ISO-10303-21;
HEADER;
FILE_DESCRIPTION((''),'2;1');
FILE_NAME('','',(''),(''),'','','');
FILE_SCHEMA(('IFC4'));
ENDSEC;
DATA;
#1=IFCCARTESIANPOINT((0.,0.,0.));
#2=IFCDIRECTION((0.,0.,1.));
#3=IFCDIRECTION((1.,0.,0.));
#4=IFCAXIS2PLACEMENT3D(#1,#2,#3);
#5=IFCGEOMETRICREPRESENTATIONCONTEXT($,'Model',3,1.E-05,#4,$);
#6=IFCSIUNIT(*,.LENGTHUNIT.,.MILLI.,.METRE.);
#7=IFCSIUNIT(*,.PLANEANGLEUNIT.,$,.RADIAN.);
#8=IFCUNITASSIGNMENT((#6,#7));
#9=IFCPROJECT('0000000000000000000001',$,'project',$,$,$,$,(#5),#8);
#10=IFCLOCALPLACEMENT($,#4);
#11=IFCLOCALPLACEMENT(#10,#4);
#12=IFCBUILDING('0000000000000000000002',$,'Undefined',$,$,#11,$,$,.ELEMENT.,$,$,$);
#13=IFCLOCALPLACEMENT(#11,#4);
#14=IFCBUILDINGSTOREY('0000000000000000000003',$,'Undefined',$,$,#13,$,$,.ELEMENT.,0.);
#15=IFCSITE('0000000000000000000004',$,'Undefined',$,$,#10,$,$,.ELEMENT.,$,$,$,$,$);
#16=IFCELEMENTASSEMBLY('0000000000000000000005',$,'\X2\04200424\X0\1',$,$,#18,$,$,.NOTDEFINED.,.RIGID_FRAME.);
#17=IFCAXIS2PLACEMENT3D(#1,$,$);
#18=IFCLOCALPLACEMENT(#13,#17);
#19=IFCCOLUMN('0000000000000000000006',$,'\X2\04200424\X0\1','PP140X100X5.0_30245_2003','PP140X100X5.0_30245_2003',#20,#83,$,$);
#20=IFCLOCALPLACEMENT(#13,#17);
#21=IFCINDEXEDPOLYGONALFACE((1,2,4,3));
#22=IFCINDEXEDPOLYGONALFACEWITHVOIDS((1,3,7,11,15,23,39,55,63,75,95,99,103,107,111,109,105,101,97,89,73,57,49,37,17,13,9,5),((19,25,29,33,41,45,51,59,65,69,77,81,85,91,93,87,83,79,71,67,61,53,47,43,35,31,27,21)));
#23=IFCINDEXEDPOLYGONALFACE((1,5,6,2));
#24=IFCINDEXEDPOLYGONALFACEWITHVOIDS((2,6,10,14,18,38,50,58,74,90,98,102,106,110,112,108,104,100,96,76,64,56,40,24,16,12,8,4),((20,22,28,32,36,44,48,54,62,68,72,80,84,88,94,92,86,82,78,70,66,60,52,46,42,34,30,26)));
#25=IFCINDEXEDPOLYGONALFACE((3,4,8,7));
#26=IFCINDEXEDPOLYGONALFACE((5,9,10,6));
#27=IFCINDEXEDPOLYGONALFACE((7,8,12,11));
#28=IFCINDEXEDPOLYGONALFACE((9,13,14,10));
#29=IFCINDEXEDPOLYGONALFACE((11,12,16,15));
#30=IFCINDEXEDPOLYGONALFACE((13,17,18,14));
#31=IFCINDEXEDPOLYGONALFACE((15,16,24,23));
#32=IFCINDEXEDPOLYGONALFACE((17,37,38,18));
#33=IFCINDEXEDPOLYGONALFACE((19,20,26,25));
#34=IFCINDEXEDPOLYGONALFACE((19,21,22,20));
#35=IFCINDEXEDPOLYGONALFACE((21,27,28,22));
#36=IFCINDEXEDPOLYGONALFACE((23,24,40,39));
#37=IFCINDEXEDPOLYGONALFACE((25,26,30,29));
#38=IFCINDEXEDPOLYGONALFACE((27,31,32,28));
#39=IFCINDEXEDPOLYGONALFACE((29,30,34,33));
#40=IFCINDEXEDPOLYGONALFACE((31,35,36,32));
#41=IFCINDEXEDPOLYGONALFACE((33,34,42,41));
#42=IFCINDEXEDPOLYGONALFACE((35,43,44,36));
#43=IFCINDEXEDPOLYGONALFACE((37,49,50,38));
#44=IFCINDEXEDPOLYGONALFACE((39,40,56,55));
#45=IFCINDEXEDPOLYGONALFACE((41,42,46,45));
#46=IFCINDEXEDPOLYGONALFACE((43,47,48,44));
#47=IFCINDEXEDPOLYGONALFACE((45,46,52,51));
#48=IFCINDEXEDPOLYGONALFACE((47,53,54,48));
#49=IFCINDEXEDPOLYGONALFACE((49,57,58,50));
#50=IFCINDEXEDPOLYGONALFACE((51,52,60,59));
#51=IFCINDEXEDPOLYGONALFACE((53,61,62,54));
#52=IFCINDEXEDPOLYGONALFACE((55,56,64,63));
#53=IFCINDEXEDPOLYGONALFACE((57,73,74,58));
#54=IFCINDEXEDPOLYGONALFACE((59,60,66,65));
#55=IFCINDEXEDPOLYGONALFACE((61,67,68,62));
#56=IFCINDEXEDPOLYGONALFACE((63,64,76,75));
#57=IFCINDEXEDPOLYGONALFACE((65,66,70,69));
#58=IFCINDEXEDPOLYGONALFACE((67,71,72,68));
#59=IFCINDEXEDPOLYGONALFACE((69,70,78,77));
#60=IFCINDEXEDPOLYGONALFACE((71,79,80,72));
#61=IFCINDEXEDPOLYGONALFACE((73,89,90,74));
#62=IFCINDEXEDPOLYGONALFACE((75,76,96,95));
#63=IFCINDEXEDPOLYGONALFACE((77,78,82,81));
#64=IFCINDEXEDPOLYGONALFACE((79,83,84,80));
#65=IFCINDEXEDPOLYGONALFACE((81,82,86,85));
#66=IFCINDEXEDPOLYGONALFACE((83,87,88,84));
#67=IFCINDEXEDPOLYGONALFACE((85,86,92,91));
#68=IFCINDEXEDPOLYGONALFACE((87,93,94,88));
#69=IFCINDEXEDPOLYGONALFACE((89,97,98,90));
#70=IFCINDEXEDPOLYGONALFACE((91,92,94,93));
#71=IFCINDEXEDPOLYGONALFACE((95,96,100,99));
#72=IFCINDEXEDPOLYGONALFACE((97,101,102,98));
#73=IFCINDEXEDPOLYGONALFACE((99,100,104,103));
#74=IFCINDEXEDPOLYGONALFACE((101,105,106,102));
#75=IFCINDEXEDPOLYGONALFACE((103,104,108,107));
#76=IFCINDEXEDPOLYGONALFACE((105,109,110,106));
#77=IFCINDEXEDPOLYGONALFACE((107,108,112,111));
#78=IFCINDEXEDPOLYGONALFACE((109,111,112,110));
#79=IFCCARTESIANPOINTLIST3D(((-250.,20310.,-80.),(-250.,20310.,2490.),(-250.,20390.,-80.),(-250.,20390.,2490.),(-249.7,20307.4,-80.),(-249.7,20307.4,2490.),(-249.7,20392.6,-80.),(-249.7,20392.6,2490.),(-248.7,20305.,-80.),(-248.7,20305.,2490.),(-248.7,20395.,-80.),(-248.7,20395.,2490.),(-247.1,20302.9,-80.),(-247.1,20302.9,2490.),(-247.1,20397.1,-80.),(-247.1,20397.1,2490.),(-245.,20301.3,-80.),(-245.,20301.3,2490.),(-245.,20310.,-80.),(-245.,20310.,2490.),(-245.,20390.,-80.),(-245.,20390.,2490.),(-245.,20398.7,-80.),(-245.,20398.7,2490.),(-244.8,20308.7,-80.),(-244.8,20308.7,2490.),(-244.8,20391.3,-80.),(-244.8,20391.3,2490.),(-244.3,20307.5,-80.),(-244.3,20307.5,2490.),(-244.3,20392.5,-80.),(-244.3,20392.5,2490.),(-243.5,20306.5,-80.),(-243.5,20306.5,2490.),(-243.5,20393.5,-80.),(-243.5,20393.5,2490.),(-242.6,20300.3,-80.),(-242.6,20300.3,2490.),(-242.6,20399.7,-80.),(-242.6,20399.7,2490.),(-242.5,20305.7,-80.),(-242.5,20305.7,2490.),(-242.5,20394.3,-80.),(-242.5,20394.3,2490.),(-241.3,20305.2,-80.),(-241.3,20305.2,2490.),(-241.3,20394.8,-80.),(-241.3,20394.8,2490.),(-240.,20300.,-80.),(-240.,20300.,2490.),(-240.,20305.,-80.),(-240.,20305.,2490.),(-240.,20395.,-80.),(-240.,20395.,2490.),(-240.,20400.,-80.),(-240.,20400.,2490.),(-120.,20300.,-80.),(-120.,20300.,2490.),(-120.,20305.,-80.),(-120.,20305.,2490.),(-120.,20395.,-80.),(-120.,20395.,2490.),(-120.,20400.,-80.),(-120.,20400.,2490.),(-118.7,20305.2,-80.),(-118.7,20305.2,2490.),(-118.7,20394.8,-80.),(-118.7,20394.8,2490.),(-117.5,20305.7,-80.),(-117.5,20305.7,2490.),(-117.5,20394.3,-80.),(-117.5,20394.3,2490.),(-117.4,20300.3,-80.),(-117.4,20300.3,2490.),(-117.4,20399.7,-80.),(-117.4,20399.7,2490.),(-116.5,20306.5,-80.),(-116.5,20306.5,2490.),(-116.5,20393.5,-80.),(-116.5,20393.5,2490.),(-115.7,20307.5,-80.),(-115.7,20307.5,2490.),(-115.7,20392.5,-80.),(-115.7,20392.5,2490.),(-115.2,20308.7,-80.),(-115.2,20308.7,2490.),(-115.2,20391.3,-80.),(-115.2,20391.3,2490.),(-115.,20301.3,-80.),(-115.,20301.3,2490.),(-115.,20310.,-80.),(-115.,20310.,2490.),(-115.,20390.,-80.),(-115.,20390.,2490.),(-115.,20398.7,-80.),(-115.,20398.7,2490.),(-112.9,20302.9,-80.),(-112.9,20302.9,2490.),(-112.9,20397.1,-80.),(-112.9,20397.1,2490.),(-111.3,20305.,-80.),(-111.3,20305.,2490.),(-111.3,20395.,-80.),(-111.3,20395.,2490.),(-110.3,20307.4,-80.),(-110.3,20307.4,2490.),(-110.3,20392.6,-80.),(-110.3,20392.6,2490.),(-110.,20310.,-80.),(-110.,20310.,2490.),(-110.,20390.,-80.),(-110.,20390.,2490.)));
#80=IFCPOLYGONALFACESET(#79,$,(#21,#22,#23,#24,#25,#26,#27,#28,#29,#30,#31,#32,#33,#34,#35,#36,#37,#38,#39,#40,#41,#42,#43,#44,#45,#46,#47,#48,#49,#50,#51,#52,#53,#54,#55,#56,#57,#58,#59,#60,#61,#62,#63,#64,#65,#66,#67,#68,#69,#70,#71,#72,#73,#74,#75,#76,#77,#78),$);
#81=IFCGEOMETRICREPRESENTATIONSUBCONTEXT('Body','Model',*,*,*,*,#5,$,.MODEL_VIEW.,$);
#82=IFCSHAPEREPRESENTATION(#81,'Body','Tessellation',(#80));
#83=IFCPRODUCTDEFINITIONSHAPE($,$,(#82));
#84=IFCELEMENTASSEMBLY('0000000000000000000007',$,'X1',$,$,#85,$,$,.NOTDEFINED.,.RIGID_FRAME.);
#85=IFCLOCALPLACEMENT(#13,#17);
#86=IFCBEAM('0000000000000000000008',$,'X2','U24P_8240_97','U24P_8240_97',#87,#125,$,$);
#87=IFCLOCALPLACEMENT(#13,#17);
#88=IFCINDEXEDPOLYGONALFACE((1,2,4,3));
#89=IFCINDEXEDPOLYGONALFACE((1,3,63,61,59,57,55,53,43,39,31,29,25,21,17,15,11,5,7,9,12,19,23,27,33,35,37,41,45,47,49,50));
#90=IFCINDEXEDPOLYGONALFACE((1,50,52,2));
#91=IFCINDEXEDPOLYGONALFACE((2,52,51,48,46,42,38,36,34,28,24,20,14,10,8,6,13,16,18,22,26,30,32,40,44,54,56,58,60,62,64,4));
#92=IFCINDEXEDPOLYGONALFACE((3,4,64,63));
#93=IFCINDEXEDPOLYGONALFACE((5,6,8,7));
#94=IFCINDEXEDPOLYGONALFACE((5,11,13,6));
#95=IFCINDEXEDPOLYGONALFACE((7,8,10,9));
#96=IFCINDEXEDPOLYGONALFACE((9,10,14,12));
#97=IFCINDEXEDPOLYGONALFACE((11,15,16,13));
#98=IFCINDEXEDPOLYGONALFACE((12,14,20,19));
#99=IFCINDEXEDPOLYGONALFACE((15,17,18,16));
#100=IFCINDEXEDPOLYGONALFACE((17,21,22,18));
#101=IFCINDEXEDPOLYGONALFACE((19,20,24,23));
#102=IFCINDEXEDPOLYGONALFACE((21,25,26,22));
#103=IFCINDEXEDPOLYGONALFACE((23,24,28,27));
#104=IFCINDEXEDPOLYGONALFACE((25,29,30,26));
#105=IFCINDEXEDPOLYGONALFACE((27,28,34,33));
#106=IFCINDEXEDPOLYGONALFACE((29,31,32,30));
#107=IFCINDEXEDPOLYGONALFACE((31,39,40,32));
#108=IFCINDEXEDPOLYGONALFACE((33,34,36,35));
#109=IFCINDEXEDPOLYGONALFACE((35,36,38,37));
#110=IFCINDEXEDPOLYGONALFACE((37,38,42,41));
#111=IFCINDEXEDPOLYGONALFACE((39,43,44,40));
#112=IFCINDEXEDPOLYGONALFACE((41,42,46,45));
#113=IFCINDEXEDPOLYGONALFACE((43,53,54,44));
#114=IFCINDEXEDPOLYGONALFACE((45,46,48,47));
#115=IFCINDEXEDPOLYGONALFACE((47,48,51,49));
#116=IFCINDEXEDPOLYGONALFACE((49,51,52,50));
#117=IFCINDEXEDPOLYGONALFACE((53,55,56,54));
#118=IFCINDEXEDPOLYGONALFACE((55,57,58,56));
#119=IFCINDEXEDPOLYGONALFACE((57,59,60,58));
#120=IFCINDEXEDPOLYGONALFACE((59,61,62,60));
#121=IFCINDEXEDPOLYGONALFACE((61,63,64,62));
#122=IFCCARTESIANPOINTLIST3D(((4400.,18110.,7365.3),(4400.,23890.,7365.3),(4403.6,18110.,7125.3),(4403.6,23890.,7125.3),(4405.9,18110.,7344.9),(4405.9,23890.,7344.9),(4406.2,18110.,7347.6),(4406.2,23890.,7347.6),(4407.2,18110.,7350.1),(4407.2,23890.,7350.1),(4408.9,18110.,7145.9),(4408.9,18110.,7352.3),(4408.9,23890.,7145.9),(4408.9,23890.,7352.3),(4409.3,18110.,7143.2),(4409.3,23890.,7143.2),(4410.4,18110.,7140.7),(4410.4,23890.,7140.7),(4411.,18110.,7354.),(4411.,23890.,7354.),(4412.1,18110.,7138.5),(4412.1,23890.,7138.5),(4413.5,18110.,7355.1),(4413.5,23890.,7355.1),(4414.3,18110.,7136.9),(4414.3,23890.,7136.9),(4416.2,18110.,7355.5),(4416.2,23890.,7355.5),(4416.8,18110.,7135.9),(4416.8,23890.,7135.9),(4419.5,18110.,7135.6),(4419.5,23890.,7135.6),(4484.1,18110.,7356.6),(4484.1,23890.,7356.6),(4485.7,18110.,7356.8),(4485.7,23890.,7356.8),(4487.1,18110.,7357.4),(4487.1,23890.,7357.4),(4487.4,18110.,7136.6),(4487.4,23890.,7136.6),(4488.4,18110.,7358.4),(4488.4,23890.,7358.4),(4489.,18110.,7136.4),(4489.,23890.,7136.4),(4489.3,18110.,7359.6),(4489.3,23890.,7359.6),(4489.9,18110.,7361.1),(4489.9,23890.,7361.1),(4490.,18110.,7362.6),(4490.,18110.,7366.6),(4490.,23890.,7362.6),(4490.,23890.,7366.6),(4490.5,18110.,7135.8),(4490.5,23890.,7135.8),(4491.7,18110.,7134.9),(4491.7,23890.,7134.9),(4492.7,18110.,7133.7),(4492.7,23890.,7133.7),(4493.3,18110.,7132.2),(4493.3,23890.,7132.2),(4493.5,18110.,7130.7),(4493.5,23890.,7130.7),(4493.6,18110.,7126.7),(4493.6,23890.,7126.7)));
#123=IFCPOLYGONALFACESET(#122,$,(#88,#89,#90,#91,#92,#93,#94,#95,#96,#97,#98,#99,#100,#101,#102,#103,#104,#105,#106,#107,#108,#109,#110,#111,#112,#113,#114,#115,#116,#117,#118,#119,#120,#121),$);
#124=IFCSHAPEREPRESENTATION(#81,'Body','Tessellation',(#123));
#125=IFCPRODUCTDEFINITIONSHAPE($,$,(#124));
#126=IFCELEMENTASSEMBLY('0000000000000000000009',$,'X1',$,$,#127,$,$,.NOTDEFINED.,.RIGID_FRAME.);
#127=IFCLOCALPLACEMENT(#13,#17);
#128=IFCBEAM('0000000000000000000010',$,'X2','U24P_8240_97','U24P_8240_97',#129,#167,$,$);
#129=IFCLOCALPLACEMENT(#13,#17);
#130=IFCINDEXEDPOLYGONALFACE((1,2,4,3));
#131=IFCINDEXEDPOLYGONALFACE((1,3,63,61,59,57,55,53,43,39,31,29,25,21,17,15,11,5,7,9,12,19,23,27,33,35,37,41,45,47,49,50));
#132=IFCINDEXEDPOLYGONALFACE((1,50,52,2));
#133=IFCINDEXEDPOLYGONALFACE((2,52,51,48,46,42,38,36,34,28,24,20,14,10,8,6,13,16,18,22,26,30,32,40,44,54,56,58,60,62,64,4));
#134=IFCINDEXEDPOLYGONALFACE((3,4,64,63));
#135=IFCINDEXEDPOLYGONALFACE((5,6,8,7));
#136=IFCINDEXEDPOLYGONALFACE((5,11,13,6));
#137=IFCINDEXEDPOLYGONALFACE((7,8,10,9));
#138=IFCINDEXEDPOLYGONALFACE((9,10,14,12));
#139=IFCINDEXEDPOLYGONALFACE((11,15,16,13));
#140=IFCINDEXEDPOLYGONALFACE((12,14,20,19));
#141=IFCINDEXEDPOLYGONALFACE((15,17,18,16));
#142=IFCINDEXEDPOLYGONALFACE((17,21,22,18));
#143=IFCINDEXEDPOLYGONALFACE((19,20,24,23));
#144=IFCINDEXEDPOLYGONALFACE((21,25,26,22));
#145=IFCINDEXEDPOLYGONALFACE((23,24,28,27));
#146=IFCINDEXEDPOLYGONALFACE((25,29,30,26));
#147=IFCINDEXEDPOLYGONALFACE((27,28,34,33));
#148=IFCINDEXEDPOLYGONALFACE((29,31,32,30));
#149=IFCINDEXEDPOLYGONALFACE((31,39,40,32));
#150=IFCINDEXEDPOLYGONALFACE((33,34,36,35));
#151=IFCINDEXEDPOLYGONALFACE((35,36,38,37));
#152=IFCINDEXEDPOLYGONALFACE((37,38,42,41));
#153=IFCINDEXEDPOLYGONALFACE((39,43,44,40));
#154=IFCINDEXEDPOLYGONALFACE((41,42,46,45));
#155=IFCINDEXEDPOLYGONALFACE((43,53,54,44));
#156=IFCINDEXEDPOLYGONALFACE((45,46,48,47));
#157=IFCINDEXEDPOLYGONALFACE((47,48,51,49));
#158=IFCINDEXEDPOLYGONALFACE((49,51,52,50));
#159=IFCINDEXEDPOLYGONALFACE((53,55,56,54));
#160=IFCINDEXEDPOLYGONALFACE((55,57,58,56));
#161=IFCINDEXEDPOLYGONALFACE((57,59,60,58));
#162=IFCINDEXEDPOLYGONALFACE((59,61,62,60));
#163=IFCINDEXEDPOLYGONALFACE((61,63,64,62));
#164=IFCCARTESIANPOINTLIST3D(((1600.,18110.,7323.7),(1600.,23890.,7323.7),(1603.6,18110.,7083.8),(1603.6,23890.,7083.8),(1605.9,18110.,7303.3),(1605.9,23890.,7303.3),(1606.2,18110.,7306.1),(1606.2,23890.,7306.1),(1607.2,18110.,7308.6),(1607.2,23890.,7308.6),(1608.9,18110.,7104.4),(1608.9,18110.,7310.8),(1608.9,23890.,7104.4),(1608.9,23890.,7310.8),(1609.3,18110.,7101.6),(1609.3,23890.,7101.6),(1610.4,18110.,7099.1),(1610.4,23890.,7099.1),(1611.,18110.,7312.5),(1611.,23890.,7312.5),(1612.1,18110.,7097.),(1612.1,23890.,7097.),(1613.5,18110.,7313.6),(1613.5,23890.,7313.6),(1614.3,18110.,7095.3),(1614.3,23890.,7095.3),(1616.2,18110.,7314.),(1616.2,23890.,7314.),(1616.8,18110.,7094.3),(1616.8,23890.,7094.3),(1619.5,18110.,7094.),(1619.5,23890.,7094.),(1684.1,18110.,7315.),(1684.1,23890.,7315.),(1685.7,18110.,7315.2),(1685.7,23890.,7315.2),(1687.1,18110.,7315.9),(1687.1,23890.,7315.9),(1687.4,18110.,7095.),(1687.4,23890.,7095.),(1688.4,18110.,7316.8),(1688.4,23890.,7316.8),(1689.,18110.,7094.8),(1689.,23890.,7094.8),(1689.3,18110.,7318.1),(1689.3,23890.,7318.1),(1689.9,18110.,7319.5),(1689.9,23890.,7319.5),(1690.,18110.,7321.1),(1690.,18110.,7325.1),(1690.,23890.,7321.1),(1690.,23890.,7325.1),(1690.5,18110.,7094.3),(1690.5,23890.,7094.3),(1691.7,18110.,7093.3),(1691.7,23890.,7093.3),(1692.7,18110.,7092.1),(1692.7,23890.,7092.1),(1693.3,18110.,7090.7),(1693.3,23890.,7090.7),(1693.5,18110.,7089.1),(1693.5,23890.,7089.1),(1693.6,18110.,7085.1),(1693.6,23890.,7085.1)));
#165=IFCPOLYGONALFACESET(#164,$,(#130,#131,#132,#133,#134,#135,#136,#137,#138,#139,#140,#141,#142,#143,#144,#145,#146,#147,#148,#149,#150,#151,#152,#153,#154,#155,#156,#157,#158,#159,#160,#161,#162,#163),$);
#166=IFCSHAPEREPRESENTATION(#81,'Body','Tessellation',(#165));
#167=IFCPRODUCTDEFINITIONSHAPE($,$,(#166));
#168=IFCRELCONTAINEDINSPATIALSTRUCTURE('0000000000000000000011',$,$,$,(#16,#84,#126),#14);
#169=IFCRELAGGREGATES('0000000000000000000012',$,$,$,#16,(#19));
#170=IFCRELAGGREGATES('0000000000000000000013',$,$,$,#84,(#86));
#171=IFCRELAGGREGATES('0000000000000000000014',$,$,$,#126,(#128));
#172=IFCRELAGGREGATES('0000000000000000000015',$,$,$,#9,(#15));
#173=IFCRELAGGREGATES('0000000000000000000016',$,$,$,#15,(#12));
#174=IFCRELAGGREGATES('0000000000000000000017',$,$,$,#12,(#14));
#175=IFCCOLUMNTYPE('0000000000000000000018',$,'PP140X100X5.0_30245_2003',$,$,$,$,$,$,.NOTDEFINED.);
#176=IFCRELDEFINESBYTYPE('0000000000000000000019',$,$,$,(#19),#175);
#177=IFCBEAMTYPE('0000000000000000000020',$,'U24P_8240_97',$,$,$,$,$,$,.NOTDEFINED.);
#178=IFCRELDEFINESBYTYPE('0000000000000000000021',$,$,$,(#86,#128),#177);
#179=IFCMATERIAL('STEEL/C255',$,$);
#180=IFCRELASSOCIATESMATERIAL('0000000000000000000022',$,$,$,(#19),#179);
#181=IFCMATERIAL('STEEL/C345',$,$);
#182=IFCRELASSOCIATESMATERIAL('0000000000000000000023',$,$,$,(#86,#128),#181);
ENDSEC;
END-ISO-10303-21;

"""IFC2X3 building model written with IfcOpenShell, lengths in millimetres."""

from ifc_helpers import new_model, si_unit, frame, origin_with_axes, origin_2d_with_axis, place, context, subcontext, project, spatial, hollow_rectangle, u_section, extrude, material, type_object, element, aggregate, save


model = new_model("IFC2X3")

# Units and contexts
model_context = context("Model", 3, precision=1e-05, world=origin_with_axes())
body_context = subcontext(model_context, "Body", "Model", "MODEL_VIEW")
ifc_project = project(units=[si_unit("LENGTHUNIT", "METRE", prefix="MILLI"), si_unit("PLANEANGLEUNIT", "RADIAN")], contexts=[model_context])

# Site, building, storey
site_placement = place(None, origin_with_axes())
site = spatial("IfcSite", under=ifc_project, at=site_placement, Name="Undefined", CompositionType="ELEMENT")
building_placement = place(site_placement, origin_with_axes())
building = spatial("IfcBuilding", under=site, at=building_placement, Name="Undefined", CompositionType="ELEMENT")
storey_placement = place(building_placement, origin_with_axes())
storey = spatial("IfcBuildingStorey", under=building, at=storey_placement, Name="Undefined", CompositionType="ELEMENT", Elevation=0.0)

# Element assembly, column
ifc_material_1 = material(Name="STEEL/C255")
column_type_1 = type_object("IfcColumnType", Name="PP140X100X5.0_30245_2003", PredefinedType="NOTDEFINED")
assembly_1_placement = place(storey_placement, origin_with_axes())
assembly_1 = element("IfcElementAssembly", 1, at=assembly_1_placement, inside=storey, Name="РФ1", AssemblyPlace="NOTDEFINED", PredefinedType="RIGID_FRAME")
column_1_placement = place(assembly_1_placement, frame((-180.0, 20350.0, -80.0), z_axis=(0.0, 0.0, 1.0), x_axis=(-1.0, 0.0, 0.0)))
column_1 = element("IfcColumn", 2, at=column_1_placement, type_object=column_type_1, material=ifc_material_1, Name="РФ1", Description="PP140X100X5.0_30245_2003", ObjectType="PP140X100X5.0_30245_2003", context=body_context, shape_type="SweptSolid", body=[
    extrude(hollow_rectangle(XDim=100.0, YDim=140.0, WallThickness=5.0, InnerFilletRadius=5.0, OuterFilletRadius=10.0, at=origin_2d_with_axis()), frame((0.0, 0.0, 2570.0), z_axis=(0.0, 0.0, -1.0), x_axis=(0.0, 1.0, 0.0)), (0.0, 0.0, 1.0), 2570.0),
])
aggregate(assembly_1, [column_1])

# Element assemblies, beams
assembly_2_placement = place(storey_placement, origin_with_axes())
assembly_2 = element("IfcElementAssembly", 3, at=assembly_2_placement, inside=storey, Name="X1", AssemblyPlace="NOTDEFINED", PredefinedType="RIGID_FRAME")
ifc_material_2 = material(Name="STEEL/C345")
beam_type_1 = type_object("IfcBeamType", Name="U24P_8240_97", PredefinedType="NOTDEFINED")
beam_1_placement = place(assembly_2_placement, frame((4446.8, 23890.0, 7246.0), z_axis=(0.014998, 0.0, -0.999888), x_axis=(0.0, -1.0, 0.0)))
beam_1 = element("IfcBeam", 4, at=beam_1_placement, type_object=beam_type_1, material=ifc_material_2, Name="X2", Description="U24P_8240_97", ObjectType="U24P_8240_97", context=body_context, shape_type="SweptSolid", body=[
    extrude(u_section(Depth=240.0, FlangeWidth=90.0, WebThickness=5.6, FlangeThickness=10.0, FilletRadius=10.5, EdgeRadius=6.0, at=origin_2d_with_axis()), frame((5780.0, 0.0, 0.0), z_axis=(-1.0, 0.0, 0.0), x_axis=(0.0, -1.0, 0.0)), (0.0, 0.0, 1.0), 5780.0),
])
aggregate(assembly_2, [beam_1])
assembly_3_placement = place(storey_placement, origin_with_axes())
assembly_3 = element("IfcElementAssembly", 5, at=assembly_3_placement, inside=storey, Name="X1", AssemblyPlace="NOTDEFINED", PredefinedType="RIGID_FRAME")
beam_2_placement = place(assembly_3_placement, frame((1646.8, 23890.0, 7204.4), z_axis=(0.014998, 0.0, -0.999888), x_axis=(0.0, -1.0, 0.0)))
beam_2 = element("IfcBeam", 6, at=beam_2_placement, type_object=beam_type_1, material=ifc_material_2, Name="X2", Description="U24P_8240_97", ObjectType="U24P_8240_97", context=body_context, shape_type="SweptSolid", body=[
    extrude(u_section(Depth=240.0, FlangeWidth=90.0, WebThickness=5.6, FlangeThickness=10.0, FilletRadius=10.5, EdgeRadius=6.0, at=origin_2d_with_axis()), frame((5780.0, 0.0, 0.0), z_axis=(-1.0, 0.0, 0.0), x_axis=(0.0, -1.0, 0.0)), (0.0, 0.0, 1.0), 5780.0),
])
aggregate(assembly_3, [beam_2])

save(model, "model.ifc")
